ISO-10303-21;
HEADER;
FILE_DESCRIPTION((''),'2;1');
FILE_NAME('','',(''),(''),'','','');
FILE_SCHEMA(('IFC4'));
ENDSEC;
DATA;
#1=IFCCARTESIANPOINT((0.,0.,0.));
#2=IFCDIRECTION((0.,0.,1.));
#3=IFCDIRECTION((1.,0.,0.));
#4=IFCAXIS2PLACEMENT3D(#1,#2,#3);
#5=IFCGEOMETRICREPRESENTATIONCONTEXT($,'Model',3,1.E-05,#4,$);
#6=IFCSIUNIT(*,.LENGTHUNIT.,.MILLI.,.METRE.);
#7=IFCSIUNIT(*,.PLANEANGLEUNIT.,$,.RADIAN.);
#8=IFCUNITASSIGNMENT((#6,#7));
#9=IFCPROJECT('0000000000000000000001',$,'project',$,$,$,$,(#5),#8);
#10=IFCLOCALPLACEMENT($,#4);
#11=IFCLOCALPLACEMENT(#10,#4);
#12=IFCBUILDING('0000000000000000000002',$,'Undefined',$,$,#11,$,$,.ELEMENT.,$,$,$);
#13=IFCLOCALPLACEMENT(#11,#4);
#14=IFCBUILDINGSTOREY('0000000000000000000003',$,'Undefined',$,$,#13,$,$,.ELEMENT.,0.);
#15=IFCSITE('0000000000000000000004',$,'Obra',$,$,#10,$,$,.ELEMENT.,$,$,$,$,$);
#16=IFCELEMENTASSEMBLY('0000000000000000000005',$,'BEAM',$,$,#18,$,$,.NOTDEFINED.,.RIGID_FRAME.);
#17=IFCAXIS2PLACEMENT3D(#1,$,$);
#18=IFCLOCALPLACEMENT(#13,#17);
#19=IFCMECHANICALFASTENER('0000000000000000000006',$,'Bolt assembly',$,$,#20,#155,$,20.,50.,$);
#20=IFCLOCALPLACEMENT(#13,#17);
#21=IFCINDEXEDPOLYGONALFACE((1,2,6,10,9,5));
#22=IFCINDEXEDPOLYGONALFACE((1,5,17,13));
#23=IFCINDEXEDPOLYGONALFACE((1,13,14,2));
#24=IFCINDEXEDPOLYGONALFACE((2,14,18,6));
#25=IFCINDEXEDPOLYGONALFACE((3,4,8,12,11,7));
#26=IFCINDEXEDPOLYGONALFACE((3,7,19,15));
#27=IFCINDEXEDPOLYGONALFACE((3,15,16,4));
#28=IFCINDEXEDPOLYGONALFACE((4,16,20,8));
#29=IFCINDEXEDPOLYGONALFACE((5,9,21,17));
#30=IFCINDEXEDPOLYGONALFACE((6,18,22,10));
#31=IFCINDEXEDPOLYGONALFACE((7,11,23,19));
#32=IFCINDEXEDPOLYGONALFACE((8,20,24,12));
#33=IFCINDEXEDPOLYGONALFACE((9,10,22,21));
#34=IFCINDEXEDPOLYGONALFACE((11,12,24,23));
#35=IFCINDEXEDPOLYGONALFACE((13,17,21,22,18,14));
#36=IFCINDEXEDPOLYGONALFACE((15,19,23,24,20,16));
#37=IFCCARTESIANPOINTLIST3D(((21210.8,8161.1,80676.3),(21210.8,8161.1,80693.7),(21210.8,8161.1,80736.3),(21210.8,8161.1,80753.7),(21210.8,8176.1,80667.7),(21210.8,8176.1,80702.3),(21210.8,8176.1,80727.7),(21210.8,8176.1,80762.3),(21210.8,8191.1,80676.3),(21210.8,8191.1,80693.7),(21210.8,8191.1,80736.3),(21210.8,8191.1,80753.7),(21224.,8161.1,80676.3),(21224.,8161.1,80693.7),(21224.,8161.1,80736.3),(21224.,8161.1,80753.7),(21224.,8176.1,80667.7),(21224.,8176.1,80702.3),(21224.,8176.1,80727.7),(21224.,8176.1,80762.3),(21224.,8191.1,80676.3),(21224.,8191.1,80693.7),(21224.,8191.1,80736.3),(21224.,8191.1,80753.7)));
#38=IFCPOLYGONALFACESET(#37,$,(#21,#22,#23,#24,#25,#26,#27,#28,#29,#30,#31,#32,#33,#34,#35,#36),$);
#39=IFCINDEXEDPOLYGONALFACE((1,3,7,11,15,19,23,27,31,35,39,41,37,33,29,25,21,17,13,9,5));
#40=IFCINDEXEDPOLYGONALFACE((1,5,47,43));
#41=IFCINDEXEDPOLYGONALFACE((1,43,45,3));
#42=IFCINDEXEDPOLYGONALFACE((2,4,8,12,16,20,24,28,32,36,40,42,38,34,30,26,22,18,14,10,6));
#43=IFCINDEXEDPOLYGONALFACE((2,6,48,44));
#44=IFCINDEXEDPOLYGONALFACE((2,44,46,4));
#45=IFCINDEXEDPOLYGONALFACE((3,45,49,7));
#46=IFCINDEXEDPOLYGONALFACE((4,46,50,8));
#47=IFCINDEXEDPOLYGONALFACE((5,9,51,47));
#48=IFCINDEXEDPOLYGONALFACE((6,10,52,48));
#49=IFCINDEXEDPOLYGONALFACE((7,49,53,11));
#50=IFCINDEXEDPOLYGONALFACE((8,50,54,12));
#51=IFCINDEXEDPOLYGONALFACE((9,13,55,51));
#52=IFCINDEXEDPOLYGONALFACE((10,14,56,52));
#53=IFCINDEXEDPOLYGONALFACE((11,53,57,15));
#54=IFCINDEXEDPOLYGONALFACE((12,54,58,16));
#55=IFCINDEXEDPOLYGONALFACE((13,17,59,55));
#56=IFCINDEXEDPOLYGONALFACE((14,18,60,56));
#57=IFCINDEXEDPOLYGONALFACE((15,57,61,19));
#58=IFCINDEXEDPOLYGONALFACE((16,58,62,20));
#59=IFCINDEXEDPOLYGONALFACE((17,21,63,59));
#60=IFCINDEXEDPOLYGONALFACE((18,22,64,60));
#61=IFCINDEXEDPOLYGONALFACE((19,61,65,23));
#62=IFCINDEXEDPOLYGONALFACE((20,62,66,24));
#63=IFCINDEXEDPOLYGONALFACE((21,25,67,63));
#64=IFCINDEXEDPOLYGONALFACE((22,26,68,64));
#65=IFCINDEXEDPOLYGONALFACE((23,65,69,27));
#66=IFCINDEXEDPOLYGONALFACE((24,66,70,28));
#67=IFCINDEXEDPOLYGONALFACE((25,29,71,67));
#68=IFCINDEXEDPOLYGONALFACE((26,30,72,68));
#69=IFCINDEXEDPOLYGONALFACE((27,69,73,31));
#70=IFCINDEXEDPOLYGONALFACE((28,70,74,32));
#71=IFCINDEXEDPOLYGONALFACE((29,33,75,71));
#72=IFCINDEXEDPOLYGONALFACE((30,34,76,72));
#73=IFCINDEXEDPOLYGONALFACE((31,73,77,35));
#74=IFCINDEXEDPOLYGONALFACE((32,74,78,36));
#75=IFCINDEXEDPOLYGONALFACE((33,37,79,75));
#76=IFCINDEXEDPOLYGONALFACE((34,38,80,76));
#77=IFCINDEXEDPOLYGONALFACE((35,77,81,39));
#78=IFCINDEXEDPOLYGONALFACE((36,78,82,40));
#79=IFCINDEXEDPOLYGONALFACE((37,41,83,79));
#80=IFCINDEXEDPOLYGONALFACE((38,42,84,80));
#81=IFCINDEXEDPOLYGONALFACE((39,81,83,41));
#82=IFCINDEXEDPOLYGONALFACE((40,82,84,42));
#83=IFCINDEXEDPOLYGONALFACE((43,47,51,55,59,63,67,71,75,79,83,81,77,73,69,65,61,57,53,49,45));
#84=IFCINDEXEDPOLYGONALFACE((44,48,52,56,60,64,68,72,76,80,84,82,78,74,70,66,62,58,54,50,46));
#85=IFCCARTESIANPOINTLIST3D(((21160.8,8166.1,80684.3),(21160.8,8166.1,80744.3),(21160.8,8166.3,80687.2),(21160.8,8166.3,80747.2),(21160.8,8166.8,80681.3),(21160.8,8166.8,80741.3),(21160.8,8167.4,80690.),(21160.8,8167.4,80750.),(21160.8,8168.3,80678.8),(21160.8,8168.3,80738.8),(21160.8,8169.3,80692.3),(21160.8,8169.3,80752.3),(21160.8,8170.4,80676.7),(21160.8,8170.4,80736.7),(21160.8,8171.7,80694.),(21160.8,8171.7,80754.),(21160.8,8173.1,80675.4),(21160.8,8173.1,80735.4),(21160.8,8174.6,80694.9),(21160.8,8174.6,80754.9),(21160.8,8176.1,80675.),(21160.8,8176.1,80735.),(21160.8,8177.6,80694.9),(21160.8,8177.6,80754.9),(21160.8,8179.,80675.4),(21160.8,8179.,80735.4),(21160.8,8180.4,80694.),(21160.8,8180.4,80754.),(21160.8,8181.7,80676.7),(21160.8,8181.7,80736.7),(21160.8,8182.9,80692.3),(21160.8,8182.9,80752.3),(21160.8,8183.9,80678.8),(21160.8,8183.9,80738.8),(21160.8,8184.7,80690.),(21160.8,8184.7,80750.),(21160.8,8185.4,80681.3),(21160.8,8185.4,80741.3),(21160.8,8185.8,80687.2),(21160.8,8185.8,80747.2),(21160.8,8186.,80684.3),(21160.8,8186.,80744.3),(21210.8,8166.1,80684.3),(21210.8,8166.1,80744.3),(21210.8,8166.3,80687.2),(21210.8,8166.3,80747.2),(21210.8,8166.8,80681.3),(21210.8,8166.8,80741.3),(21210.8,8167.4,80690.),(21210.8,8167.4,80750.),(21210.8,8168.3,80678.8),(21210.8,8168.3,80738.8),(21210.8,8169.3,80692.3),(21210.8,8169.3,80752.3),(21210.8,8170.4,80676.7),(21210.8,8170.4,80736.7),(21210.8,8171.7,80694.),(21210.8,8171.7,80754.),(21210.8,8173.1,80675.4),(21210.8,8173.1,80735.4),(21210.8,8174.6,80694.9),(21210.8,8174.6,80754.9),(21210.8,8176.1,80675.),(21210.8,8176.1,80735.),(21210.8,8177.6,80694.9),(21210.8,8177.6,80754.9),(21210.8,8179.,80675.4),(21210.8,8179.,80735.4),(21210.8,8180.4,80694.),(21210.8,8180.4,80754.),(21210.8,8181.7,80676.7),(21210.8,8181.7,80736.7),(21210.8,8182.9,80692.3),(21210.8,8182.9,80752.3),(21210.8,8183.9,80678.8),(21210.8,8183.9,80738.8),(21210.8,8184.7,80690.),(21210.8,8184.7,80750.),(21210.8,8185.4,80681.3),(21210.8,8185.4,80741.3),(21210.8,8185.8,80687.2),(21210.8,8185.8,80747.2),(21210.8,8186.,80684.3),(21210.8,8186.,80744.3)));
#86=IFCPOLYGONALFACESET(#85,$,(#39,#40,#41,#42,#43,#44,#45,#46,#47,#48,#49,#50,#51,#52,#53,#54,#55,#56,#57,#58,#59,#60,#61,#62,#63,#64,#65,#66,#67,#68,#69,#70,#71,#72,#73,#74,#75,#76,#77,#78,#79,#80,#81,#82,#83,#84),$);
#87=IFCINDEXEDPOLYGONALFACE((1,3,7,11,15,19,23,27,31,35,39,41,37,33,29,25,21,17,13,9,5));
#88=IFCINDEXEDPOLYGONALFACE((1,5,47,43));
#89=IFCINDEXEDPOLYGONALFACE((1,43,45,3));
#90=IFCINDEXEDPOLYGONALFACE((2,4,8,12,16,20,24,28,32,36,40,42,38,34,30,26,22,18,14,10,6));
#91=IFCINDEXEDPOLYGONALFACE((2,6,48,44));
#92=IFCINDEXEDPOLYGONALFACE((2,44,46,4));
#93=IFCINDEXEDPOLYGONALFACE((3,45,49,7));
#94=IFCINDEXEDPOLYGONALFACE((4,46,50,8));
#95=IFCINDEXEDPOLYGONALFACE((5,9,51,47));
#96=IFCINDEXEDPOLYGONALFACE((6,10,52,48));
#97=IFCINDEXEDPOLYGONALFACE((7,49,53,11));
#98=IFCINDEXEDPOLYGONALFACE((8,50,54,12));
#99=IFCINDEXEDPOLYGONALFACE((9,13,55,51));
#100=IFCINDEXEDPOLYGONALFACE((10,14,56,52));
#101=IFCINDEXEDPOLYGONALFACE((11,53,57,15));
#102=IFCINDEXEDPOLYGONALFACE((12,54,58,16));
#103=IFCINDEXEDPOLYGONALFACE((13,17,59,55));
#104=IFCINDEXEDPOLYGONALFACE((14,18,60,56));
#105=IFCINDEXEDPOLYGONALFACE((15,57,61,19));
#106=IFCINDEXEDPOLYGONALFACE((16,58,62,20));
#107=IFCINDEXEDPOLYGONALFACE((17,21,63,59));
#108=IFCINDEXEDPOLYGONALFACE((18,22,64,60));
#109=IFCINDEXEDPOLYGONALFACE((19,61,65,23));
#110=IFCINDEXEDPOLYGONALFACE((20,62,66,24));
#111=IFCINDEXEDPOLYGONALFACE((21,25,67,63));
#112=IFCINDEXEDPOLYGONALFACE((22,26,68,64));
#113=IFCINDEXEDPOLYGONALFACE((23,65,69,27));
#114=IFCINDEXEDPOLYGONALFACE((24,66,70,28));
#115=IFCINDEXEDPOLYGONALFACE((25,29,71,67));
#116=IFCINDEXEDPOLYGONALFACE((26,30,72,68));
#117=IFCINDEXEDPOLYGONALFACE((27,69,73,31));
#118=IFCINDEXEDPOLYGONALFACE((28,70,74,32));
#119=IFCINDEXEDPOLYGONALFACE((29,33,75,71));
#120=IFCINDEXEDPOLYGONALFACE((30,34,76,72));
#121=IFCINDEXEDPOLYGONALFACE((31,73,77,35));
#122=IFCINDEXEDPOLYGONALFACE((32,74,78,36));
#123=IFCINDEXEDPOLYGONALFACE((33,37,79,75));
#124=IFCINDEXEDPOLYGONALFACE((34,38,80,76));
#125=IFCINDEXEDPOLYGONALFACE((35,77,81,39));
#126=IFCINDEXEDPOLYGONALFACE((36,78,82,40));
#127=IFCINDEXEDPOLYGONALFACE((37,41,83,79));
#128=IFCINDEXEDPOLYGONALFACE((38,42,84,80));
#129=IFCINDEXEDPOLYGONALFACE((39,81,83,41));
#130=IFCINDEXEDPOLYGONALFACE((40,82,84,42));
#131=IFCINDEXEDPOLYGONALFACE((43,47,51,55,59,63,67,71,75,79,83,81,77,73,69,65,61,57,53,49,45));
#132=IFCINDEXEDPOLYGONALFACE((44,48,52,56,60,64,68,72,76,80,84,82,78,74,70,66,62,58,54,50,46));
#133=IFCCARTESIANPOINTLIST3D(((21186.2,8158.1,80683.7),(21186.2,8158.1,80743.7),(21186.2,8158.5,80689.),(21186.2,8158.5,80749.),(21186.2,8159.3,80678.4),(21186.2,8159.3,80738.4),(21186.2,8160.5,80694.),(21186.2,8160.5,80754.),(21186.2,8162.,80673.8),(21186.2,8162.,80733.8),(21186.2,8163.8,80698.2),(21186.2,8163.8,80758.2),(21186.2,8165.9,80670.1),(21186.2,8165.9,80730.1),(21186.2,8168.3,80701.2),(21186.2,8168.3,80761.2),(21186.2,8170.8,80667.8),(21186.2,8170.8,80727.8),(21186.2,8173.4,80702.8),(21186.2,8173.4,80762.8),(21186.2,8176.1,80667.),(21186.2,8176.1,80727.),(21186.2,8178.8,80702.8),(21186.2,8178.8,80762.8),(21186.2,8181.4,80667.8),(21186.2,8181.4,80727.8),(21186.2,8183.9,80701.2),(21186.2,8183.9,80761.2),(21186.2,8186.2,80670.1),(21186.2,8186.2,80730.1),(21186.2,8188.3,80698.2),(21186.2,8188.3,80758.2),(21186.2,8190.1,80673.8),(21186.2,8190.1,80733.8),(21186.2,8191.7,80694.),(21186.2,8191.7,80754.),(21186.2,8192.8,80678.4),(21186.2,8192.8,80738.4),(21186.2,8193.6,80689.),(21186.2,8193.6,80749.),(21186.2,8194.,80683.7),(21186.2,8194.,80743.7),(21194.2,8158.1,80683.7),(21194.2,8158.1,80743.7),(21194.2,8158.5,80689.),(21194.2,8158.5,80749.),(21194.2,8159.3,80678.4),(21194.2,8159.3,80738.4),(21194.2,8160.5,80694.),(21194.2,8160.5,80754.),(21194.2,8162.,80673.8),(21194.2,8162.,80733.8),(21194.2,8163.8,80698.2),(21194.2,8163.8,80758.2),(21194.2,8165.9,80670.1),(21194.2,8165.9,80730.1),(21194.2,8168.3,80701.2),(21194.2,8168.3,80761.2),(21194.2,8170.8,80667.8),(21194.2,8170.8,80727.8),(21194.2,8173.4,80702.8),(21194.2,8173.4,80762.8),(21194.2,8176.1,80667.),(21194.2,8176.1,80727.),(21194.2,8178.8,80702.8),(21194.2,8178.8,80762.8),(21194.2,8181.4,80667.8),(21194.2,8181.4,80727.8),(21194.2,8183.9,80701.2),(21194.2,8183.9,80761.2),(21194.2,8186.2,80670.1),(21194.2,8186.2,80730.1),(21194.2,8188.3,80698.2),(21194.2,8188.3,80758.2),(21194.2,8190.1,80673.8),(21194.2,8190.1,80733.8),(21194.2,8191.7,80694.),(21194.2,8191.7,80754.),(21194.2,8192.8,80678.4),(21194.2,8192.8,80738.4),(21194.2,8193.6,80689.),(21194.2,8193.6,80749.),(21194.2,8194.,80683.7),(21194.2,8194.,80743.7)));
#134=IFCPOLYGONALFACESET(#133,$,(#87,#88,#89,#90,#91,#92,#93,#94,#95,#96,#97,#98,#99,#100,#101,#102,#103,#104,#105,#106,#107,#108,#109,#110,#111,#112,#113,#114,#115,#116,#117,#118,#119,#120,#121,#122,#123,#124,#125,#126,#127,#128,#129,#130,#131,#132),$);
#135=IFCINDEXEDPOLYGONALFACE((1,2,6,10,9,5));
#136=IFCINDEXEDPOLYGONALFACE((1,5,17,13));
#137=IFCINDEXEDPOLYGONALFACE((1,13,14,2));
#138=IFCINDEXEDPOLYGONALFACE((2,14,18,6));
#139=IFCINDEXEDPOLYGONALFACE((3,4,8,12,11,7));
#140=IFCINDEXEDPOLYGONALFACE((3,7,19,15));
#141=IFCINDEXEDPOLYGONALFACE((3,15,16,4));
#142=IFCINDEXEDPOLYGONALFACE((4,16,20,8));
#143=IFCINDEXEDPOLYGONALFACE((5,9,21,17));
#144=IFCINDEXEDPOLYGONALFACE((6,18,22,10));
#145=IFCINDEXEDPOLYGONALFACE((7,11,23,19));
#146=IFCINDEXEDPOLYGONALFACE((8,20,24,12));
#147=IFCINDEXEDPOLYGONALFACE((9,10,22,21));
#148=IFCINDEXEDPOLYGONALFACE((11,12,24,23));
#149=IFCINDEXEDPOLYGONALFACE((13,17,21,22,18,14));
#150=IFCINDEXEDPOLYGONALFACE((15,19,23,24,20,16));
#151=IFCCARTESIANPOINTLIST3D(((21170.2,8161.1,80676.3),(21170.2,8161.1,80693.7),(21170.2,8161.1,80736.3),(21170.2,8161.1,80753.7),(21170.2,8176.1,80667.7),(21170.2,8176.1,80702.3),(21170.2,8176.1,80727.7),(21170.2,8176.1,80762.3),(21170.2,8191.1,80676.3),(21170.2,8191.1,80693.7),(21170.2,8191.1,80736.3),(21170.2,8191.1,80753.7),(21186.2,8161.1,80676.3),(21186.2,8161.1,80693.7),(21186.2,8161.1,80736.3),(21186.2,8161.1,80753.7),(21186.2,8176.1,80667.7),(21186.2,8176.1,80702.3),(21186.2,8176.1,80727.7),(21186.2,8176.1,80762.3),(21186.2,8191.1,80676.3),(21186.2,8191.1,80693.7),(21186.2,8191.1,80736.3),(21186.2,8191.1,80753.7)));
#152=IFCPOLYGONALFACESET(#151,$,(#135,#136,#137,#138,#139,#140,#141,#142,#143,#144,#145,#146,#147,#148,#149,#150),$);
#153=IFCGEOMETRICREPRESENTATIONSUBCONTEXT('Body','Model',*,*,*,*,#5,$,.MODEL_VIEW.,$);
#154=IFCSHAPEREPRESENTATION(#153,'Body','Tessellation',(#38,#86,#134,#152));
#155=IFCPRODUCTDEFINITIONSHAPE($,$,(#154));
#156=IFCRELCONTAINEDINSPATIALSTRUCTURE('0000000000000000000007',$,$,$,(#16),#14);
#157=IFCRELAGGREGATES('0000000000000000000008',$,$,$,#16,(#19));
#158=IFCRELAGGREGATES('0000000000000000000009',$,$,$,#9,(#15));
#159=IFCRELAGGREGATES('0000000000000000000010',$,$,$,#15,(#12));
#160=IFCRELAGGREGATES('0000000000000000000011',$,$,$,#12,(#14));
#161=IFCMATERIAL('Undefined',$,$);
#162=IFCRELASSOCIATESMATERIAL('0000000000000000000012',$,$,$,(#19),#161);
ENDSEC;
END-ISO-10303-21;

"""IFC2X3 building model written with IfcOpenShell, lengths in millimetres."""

from ifc_helpers import new_model, si_unit, frame, origin_with_axes, origin_2d_with_axis, place, context, subcontext, project, spatial, polyline, circle, outline, extrude, source, transform, mapped, material, element, aggregate, save


model = new_model("IFC2X3")

# Units and contexts
model_context = context("Model", 3, precision=1e-05, world=origin_with_axes())
body_context = subcontext(model_context, "Body", "Model", "MODEL_VIEW")
ifc_project = project(units=[si_unit("LENGTHUNIT", "METRE", prefix="MILLI"), si_unit("PLANEANGLEUNIT", "RADIAN")], contexts=[model_context])

# Site, building, storey
site_placement = place(None, origin_with_axes())
site = spatial("IfcSite", under=ifc_project, at=site_placement, Name="Obra", CompositionType="ELEMENT")
building_placement = place(site_placement, origin_with_axes())
building = spatial("IfcBuilding", under=site, at=building_placement, Name="Undefined", CompositionType="ELEMENT")
storey_placement = place(building_placement, origin_with_axes())
storey = spatial("IfcBuildingStorey", under=building, at=storey_placement, Name="Undefined", CompositionType="ELEMENT", Elevation=0.0)

# Element assembly
ifc_material_1 = material(Name="Undefined")
shared_shape_1 = source(origin_with_axes(), body_context, "Body", "SweptSolid", [
    extrude(outline(polyline([(17.3, 0.0), (8.7, 15.0), (-8.7, 15.0), (-17.3, 0.0), (-8.7, -15.0), (8.7, -15.0), (17.3, 0.0)])), frame((0.0, -26.5, 0.0), z_axis=(0.0, 1.0, 0.0), x_axis=(1.0, 0.0, 0.0)), (0.0, 0.0, 1.0), 13.2),
    extrude(circle(Radius=10.0, at=origin_2d_with_axis()), frame((0.0, -13.3, 0.0), z_axis=(0.0, 1.0, 0.0), x_axis=(1.0, 0.0, 0.0)), (0.0, 0.0, 1.0), 50.0),
    extrude(circle(Radius=18.0, at=origin_2d_with_axis()), frame((0.0, 3.3, 0.0), z_axis=(0.0, 1.0, 0.0), x_axis=(1.0, 0.0, 0.0)), (0.0, 0.0, 1.0), 8.0),
    extrude(outline(polyline([(17.3, 0.0), (8.7, 15.0), (-8.7, 15.0), (-17.3, 0.0), (-8.7, -15.0), (8.7, -15.0), (17.3, 0.0)])), frame((0.0, 11.3, 0.0), z_axis=(0.0, 1.0, 0.0), x_axis=(1.0, 0.0, 0.0)), (0.0, 0.0, 1.0), 16.0),
])
assembly_1_placement = place(storey_placement, origin_with_axes())
assembly_1 = element("IfcElementAssembly", 1, at=assembly_1_placement, inside=storey, Name="BEAM", AssemblyPlace="NOTDEFINED", PredefinedType="RIGID_FRAME")

# Mechanical fastener
mechanical_fastener_1_placement = place(assembly_1_placement, frame((21197.5, 8136.1, 80850.0), z_axis=(0.0, 1.0, 0.0), x_axis=(0.0, 0.0, -1.0)))
mechanical_fastener_1 = element("IfcMechanicalFastener", 2, at=mechanical_fastener_1_placement, material=ifc_material_1, Name="Bolt assembly", NominalDiameter=20.0, NominalLength=50.0, context=body_context, shape_type="MappedRepresentation", body=[
    mapped(shared_shape_1, transform((105.0, 0.0, 40.0))),
    mapped(shared_shape_1, transform((165.0, 0.0, 40.0))),
])
aggregate(assembly_1, [mechanical_fastener_1])

save(model, "model.ifc")
